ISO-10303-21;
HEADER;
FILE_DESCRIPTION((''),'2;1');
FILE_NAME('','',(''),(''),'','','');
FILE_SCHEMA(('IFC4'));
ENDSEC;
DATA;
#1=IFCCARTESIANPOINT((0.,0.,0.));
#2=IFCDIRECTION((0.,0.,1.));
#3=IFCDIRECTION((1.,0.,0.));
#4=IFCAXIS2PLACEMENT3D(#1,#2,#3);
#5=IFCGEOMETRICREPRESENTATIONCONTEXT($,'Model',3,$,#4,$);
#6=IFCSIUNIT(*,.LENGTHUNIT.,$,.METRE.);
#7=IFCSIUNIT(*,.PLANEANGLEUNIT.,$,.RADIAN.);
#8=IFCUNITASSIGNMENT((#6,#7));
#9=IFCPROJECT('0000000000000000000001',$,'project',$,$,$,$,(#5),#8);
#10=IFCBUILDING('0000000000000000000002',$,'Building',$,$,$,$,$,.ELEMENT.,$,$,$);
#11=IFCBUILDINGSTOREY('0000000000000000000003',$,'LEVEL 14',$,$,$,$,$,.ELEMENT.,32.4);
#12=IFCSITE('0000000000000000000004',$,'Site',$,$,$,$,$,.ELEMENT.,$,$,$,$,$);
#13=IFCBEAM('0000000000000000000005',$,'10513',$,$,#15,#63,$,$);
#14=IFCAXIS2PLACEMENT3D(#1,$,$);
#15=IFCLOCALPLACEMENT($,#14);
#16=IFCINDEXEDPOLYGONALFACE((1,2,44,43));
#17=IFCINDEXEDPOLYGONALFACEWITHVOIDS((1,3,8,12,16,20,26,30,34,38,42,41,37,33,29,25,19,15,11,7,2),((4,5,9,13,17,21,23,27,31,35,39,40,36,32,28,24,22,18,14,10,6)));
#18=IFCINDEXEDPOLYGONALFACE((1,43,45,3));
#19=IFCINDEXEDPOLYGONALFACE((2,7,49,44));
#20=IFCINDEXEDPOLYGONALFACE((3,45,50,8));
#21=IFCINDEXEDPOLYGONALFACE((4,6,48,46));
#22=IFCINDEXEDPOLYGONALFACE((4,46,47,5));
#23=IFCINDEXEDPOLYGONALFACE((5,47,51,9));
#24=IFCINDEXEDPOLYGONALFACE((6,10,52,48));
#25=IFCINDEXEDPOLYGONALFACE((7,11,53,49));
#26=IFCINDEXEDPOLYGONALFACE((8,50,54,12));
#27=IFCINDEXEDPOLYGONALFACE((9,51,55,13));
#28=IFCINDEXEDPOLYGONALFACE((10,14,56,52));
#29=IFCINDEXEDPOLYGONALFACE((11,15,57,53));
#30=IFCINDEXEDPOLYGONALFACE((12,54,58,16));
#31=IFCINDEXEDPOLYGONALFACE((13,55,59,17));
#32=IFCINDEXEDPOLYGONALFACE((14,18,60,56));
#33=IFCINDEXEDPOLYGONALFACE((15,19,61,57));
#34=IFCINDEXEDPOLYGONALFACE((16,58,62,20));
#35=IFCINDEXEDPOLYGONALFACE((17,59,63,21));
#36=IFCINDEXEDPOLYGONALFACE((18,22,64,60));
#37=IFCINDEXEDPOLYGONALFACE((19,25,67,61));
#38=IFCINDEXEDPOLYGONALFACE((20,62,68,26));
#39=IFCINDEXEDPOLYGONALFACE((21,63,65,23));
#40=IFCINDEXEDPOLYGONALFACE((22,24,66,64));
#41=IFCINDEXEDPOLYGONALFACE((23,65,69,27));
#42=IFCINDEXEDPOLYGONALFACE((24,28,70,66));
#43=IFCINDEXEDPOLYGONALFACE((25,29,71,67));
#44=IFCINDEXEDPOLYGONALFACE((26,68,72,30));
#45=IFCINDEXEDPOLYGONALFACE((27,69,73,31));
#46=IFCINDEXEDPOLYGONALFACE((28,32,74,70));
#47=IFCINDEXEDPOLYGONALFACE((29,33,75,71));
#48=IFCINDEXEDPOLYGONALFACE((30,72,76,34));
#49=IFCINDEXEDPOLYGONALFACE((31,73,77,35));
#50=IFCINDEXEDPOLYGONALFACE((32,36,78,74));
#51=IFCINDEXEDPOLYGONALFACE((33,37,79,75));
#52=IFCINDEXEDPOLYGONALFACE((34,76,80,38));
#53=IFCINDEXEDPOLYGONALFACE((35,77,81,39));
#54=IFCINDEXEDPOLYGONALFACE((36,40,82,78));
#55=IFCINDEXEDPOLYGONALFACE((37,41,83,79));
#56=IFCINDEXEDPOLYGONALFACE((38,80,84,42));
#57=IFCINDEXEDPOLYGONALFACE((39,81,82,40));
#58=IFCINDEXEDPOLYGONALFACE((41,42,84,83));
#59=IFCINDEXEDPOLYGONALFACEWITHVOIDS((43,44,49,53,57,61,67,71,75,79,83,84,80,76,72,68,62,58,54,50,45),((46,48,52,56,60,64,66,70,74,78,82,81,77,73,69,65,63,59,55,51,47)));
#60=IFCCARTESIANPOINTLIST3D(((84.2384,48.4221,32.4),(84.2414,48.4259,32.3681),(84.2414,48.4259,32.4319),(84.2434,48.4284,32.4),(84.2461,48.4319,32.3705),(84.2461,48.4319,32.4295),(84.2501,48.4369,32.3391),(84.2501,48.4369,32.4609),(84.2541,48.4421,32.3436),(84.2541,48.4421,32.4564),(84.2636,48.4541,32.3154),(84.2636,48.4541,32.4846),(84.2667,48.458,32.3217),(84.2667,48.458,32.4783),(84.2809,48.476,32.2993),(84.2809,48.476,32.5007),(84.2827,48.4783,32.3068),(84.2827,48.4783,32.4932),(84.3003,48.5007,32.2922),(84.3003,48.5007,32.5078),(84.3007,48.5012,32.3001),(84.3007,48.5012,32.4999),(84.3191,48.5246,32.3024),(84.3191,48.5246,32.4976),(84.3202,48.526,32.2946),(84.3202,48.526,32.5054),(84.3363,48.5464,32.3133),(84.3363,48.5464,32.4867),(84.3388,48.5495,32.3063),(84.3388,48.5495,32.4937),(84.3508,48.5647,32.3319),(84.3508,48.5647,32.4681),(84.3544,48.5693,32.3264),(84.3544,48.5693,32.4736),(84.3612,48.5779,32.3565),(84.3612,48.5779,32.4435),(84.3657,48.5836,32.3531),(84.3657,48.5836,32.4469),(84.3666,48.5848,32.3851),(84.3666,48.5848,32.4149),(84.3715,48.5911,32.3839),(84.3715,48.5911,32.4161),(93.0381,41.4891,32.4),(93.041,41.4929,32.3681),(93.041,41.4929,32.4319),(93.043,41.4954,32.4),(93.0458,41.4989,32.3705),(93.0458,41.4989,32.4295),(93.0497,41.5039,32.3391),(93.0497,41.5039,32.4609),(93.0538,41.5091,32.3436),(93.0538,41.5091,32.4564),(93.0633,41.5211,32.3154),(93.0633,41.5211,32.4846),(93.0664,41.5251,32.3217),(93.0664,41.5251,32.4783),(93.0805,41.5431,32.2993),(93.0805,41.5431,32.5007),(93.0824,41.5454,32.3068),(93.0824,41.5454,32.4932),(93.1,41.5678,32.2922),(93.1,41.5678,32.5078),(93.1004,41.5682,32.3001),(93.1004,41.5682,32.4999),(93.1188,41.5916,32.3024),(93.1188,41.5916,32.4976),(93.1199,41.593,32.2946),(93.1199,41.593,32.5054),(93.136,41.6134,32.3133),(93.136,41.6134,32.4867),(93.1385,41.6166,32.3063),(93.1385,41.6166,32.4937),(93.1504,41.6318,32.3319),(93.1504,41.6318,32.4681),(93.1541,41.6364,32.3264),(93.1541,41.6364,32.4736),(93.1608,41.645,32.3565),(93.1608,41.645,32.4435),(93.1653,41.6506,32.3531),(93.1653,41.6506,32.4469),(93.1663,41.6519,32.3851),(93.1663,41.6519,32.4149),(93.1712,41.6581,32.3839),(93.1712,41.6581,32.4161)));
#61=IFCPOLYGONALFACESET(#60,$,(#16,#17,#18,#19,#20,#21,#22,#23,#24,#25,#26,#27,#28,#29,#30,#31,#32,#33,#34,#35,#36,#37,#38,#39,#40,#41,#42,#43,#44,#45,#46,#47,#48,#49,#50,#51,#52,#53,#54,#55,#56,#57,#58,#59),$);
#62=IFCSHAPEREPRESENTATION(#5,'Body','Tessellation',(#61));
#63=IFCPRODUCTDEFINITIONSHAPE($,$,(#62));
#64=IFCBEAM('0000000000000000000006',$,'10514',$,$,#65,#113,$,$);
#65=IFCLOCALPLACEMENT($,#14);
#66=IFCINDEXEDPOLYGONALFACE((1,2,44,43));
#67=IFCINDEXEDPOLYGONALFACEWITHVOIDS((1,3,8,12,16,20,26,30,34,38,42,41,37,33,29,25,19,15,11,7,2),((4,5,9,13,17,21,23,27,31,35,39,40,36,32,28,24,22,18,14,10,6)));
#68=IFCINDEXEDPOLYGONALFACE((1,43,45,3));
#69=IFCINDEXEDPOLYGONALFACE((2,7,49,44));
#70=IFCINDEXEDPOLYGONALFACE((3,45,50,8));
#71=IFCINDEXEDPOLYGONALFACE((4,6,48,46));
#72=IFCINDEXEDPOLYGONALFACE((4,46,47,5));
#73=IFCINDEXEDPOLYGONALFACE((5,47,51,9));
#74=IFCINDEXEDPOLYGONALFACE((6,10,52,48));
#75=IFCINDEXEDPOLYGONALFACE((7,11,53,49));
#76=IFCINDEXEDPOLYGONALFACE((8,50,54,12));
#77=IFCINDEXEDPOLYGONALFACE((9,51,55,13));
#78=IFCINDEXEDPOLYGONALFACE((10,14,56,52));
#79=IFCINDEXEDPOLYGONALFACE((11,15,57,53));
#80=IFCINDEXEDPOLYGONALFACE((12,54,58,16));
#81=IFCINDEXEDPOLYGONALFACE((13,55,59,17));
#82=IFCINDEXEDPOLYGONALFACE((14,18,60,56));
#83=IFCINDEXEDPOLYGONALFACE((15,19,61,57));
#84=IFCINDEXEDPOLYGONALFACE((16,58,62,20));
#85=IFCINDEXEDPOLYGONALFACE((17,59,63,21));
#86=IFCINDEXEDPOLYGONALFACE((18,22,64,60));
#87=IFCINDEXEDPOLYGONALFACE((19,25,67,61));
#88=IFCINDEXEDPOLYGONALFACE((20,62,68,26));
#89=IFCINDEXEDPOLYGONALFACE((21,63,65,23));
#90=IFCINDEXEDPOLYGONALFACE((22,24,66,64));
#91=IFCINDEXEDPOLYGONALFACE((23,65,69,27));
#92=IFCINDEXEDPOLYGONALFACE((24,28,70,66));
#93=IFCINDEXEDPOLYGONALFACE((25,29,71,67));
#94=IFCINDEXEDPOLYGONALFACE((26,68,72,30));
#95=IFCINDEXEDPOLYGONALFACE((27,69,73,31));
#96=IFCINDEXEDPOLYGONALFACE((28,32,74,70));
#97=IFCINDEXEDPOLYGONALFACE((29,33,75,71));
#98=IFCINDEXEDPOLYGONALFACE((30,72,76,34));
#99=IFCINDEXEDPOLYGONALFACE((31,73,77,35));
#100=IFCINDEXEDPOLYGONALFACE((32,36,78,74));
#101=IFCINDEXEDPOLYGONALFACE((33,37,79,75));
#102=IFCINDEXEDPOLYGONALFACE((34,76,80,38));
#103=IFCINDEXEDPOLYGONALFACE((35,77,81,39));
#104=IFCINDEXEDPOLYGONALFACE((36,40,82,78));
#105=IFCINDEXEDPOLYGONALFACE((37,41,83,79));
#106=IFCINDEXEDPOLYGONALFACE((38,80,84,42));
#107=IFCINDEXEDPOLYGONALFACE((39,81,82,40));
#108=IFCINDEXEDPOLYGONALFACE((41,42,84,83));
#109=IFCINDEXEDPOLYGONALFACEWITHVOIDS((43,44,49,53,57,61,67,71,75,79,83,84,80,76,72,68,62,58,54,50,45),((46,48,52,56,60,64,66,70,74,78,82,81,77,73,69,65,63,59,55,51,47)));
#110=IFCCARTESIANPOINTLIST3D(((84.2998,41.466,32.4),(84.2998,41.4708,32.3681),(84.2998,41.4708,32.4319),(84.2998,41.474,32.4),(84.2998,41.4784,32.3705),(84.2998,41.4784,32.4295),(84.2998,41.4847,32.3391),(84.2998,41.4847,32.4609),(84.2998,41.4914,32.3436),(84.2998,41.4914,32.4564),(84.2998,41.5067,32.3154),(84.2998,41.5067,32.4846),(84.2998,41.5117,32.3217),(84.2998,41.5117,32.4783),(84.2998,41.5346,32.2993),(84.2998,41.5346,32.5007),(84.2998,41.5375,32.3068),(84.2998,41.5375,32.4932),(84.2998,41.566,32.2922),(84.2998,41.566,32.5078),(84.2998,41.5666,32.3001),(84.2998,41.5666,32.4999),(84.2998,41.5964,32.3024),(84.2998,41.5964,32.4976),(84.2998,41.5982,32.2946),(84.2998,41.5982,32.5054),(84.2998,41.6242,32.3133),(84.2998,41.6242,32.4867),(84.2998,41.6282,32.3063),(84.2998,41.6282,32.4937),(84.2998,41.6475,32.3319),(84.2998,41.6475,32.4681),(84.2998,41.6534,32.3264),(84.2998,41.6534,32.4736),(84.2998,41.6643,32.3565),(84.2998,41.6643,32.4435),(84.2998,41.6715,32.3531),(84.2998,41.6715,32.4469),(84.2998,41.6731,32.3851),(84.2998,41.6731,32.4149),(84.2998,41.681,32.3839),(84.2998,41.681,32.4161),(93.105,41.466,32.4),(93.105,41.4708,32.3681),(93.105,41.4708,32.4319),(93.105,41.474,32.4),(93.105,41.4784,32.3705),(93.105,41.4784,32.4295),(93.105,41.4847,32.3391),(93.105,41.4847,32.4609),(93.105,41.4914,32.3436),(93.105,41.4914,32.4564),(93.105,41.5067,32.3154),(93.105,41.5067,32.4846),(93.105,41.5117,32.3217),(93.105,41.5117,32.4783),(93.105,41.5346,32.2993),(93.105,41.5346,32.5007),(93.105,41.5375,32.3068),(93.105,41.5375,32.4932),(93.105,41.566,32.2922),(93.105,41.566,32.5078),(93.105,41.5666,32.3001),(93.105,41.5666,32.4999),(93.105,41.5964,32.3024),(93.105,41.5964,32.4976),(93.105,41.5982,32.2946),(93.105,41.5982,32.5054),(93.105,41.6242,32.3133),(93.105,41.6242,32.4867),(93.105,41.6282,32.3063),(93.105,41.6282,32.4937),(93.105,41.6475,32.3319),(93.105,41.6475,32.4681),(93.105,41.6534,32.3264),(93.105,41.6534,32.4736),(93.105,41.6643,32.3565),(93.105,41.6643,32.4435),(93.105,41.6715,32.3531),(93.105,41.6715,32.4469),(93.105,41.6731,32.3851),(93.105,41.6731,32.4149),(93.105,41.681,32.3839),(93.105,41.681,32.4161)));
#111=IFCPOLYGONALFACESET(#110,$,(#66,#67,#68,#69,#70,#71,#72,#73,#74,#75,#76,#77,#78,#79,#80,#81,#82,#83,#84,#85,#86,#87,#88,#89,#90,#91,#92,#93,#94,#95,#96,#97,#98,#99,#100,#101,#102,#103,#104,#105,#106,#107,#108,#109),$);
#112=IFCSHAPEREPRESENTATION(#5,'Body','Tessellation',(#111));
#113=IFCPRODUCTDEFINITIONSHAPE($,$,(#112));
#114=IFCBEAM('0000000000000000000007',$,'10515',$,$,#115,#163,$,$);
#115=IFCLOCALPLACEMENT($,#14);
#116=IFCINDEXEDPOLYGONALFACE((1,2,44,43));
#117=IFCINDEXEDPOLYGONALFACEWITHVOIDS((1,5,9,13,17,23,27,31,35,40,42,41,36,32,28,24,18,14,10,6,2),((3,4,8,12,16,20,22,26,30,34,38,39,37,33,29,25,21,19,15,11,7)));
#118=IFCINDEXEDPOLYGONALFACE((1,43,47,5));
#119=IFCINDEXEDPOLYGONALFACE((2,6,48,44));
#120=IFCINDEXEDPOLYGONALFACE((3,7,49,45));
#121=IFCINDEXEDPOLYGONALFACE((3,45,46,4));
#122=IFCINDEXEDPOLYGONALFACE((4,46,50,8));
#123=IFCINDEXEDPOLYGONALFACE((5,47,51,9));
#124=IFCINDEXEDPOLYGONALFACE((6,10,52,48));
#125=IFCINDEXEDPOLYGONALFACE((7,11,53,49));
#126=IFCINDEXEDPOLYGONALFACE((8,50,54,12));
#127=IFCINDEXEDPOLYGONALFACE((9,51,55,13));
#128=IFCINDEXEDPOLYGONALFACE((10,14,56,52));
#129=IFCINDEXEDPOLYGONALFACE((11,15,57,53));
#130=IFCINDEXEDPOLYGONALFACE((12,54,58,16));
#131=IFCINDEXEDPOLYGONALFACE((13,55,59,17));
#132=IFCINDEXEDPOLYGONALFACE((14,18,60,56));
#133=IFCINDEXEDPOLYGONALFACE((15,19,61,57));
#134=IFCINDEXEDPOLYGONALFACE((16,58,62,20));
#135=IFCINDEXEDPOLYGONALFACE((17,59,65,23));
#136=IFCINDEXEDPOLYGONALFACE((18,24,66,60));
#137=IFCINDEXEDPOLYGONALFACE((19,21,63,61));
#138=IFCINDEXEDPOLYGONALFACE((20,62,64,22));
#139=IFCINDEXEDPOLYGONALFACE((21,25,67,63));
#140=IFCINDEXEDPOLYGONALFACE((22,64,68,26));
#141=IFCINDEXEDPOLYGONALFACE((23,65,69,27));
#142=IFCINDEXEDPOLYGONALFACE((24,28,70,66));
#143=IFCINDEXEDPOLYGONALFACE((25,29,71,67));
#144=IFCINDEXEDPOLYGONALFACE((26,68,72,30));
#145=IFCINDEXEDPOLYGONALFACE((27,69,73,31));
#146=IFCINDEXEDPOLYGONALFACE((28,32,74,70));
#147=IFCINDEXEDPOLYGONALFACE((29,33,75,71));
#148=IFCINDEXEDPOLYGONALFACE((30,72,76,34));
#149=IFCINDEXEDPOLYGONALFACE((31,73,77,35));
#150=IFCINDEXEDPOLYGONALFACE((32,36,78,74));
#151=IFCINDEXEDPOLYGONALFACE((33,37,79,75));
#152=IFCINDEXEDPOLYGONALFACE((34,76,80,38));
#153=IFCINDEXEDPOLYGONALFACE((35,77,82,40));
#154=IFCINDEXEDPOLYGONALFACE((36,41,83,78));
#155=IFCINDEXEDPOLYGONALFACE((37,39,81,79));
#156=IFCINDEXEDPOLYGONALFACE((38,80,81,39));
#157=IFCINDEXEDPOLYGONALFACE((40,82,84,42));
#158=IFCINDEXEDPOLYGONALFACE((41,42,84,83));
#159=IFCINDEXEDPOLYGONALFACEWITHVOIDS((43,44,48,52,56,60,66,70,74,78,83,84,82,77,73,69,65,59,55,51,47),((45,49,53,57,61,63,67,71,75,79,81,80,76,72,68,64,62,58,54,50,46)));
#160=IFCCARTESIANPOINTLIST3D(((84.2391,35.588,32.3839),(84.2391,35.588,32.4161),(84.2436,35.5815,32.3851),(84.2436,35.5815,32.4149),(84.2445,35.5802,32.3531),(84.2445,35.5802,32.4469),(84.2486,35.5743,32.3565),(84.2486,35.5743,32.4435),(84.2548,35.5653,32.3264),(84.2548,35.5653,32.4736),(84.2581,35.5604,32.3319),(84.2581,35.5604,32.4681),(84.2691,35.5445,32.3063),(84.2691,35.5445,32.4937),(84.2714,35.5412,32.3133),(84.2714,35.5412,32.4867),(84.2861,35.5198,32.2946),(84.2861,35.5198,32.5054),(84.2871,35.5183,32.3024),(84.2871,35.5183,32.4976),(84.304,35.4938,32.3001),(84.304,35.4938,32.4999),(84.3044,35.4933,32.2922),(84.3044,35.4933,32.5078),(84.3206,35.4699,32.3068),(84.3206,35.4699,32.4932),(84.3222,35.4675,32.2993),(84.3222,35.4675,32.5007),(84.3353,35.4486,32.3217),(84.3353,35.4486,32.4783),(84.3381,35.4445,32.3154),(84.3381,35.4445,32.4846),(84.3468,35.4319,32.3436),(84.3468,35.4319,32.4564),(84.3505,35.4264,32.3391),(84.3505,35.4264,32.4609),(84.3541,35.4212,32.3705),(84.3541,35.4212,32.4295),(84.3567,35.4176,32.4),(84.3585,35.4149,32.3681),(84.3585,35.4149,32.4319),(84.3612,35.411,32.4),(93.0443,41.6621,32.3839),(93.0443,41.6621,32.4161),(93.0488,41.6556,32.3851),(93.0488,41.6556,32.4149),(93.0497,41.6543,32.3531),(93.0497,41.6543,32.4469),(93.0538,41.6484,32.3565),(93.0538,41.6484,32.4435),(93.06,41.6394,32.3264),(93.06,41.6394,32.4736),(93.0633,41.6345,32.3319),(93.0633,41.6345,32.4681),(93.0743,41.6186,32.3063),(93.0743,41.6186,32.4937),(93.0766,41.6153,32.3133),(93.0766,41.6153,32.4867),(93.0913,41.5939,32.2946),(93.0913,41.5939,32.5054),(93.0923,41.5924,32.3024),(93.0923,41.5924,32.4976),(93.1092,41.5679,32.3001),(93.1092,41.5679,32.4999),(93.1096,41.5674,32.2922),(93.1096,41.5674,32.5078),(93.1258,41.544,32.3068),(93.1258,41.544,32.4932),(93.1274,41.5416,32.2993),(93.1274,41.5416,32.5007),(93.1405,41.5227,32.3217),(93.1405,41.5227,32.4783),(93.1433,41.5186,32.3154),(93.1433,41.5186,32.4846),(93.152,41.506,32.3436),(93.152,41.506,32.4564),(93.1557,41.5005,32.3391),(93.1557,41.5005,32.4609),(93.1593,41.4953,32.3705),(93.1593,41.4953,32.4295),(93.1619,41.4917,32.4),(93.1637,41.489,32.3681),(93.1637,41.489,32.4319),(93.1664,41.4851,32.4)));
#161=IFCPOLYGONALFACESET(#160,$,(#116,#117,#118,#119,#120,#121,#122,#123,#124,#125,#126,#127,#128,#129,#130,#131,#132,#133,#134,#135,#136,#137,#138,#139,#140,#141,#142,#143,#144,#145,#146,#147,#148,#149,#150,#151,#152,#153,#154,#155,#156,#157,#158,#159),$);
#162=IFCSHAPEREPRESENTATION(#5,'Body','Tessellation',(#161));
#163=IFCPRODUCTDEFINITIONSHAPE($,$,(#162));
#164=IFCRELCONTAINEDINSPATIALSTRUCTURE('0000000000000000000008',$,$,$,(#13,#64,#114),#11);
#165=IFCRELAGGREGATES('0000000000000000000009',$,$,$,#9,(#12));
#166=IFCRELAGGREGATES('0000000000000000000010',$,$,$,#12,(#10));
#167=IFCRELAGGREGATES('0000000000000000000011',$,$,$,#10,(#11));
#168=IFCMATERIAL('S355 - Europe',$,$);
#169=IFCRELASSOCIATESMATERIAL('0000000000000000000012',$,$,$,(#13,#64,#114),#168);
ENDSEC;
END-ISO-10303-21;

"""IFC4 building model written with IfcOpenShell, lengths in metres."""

from ifc_helpers import new_model, si_unit, frame, origin_with_axes, origin_2d_with_axis, place, context, project, spatial, hollow_circle, extrude, material, material_profile, profile_set, profile_usage, element, save


model = new_model("IFC4")

# Units and contexts
model_context = context("Model", 3, world=origin_with_axes())
ifc_project = project(units=[si_unit("LENGTHUNIT", "METRE"), si_unit("PLANEANGLEUNIT", "RADIAN")], contexts=[model_context])

# Site, building, storey
site = spatial("IfcSite", under=ifc_project, Name="Site", CompositionType="ELEMENT")
building = spatial("IfcBuilding", under=site, Name="Building", CompositionType="ELEMENT")
storey = spatial("IfcBuildingStorey", under=building, Name="LEVEL 14", CompositionType="ELEMENT", Elevation=32.4)

# Shared definitions
ifc_material = material(Name="S355 - Europe")

# Beams
ifc_material_profile_1 = material_profile(ifc_material, hollow_circle(Radius=0.1081, WallThickness=0.008, at=origin_2d_with_axis()))
ifc_profile_set_1 = profile_set([ifc_material_profile_1])
ifc_profile_usage_1 = profile_usage(ifc_profile_set_1, cardinal=10)
beam_1_placement = place(None, frame((93.105, 41.5741, 32.4), z_axis=(-0.785496, 0.618866, 0.0), x_axis=(-0.618237, -0.785992, 0.0)))
element("IfcBeam", 1, at=beam_1_placement, inside=storey, material=ifc_profile_usage_1, Name="10513", context=model_context, shape_type="SweptSolid", body=[
    extrude(hollow_circle(Radius=0.1081, WallThickness=0.008, at=origin_2d_with_axis()), origin_with_axes(), (0.0, 0.0, 1.0), 11.2027),
])
ifc_material_profile_2 = material_profile(ifc_material, hollow_circle(Radius=0.1081, WallThickness=0.008, at=origin_2d_with_axis()))
ifc_profile_set_2 = profile_set([ifc_material_profile_2])
ifc_profile_usage_2 = profile_usage(ifc_profile_set_2, cardinal=10)
beam_2_placement = place(None, frame((93.105, 41.5741, 32.4), z_axis=(-1.0, 0.0, 0.0), x_axis=(0.0, -1.0, 0.0)))
element("IfcBeam", 2, at=beam_2_placement, inside=storey, material=ifc_profile_usage_2, Name="10514", context=model_context, shape_type="SweptSolid", body=[
    extrude(hollow_circle(Radius=0.1081, WallThickness=0.008, at=origin_2d_with_axis()), origin_with_axes(), (0.0, 0.0, 1.0), 8.8052),
])
ifc_material_profile_3 = material_profile(ifc_material, hollow_circle(Radius=0.1081, WallThickness=0.008, at=origin_2d_with_axis()))
ifc_profile_set_3 = profile_set([ifc_material_profile_3])
ifc_profile_usage_3 = profile_usage(ifc_profile_set_3, cardinal=10)
beam_3_placement = place(None, frame((93.105, 41.5741, 32.4), z_axis=(-0.823145, -0.567831, 0.0), x_axis=(0.567831, -0.823145, 0.0)))
element("IfcBeam", 3, at=beam_3_placement, inside=storey, material=ifc_profile_usage_3, Name="10515", context=model_context, shape_type="SweptSolid", body=[
    extrude(hollow_circle(Radius=0.1081, WallThickness=0.008, at=origin_2d_with_axis()), origin_with_axes(), (0.0, 0.0, 1.0), 10.697),
])

save(model, "model.ifc")
